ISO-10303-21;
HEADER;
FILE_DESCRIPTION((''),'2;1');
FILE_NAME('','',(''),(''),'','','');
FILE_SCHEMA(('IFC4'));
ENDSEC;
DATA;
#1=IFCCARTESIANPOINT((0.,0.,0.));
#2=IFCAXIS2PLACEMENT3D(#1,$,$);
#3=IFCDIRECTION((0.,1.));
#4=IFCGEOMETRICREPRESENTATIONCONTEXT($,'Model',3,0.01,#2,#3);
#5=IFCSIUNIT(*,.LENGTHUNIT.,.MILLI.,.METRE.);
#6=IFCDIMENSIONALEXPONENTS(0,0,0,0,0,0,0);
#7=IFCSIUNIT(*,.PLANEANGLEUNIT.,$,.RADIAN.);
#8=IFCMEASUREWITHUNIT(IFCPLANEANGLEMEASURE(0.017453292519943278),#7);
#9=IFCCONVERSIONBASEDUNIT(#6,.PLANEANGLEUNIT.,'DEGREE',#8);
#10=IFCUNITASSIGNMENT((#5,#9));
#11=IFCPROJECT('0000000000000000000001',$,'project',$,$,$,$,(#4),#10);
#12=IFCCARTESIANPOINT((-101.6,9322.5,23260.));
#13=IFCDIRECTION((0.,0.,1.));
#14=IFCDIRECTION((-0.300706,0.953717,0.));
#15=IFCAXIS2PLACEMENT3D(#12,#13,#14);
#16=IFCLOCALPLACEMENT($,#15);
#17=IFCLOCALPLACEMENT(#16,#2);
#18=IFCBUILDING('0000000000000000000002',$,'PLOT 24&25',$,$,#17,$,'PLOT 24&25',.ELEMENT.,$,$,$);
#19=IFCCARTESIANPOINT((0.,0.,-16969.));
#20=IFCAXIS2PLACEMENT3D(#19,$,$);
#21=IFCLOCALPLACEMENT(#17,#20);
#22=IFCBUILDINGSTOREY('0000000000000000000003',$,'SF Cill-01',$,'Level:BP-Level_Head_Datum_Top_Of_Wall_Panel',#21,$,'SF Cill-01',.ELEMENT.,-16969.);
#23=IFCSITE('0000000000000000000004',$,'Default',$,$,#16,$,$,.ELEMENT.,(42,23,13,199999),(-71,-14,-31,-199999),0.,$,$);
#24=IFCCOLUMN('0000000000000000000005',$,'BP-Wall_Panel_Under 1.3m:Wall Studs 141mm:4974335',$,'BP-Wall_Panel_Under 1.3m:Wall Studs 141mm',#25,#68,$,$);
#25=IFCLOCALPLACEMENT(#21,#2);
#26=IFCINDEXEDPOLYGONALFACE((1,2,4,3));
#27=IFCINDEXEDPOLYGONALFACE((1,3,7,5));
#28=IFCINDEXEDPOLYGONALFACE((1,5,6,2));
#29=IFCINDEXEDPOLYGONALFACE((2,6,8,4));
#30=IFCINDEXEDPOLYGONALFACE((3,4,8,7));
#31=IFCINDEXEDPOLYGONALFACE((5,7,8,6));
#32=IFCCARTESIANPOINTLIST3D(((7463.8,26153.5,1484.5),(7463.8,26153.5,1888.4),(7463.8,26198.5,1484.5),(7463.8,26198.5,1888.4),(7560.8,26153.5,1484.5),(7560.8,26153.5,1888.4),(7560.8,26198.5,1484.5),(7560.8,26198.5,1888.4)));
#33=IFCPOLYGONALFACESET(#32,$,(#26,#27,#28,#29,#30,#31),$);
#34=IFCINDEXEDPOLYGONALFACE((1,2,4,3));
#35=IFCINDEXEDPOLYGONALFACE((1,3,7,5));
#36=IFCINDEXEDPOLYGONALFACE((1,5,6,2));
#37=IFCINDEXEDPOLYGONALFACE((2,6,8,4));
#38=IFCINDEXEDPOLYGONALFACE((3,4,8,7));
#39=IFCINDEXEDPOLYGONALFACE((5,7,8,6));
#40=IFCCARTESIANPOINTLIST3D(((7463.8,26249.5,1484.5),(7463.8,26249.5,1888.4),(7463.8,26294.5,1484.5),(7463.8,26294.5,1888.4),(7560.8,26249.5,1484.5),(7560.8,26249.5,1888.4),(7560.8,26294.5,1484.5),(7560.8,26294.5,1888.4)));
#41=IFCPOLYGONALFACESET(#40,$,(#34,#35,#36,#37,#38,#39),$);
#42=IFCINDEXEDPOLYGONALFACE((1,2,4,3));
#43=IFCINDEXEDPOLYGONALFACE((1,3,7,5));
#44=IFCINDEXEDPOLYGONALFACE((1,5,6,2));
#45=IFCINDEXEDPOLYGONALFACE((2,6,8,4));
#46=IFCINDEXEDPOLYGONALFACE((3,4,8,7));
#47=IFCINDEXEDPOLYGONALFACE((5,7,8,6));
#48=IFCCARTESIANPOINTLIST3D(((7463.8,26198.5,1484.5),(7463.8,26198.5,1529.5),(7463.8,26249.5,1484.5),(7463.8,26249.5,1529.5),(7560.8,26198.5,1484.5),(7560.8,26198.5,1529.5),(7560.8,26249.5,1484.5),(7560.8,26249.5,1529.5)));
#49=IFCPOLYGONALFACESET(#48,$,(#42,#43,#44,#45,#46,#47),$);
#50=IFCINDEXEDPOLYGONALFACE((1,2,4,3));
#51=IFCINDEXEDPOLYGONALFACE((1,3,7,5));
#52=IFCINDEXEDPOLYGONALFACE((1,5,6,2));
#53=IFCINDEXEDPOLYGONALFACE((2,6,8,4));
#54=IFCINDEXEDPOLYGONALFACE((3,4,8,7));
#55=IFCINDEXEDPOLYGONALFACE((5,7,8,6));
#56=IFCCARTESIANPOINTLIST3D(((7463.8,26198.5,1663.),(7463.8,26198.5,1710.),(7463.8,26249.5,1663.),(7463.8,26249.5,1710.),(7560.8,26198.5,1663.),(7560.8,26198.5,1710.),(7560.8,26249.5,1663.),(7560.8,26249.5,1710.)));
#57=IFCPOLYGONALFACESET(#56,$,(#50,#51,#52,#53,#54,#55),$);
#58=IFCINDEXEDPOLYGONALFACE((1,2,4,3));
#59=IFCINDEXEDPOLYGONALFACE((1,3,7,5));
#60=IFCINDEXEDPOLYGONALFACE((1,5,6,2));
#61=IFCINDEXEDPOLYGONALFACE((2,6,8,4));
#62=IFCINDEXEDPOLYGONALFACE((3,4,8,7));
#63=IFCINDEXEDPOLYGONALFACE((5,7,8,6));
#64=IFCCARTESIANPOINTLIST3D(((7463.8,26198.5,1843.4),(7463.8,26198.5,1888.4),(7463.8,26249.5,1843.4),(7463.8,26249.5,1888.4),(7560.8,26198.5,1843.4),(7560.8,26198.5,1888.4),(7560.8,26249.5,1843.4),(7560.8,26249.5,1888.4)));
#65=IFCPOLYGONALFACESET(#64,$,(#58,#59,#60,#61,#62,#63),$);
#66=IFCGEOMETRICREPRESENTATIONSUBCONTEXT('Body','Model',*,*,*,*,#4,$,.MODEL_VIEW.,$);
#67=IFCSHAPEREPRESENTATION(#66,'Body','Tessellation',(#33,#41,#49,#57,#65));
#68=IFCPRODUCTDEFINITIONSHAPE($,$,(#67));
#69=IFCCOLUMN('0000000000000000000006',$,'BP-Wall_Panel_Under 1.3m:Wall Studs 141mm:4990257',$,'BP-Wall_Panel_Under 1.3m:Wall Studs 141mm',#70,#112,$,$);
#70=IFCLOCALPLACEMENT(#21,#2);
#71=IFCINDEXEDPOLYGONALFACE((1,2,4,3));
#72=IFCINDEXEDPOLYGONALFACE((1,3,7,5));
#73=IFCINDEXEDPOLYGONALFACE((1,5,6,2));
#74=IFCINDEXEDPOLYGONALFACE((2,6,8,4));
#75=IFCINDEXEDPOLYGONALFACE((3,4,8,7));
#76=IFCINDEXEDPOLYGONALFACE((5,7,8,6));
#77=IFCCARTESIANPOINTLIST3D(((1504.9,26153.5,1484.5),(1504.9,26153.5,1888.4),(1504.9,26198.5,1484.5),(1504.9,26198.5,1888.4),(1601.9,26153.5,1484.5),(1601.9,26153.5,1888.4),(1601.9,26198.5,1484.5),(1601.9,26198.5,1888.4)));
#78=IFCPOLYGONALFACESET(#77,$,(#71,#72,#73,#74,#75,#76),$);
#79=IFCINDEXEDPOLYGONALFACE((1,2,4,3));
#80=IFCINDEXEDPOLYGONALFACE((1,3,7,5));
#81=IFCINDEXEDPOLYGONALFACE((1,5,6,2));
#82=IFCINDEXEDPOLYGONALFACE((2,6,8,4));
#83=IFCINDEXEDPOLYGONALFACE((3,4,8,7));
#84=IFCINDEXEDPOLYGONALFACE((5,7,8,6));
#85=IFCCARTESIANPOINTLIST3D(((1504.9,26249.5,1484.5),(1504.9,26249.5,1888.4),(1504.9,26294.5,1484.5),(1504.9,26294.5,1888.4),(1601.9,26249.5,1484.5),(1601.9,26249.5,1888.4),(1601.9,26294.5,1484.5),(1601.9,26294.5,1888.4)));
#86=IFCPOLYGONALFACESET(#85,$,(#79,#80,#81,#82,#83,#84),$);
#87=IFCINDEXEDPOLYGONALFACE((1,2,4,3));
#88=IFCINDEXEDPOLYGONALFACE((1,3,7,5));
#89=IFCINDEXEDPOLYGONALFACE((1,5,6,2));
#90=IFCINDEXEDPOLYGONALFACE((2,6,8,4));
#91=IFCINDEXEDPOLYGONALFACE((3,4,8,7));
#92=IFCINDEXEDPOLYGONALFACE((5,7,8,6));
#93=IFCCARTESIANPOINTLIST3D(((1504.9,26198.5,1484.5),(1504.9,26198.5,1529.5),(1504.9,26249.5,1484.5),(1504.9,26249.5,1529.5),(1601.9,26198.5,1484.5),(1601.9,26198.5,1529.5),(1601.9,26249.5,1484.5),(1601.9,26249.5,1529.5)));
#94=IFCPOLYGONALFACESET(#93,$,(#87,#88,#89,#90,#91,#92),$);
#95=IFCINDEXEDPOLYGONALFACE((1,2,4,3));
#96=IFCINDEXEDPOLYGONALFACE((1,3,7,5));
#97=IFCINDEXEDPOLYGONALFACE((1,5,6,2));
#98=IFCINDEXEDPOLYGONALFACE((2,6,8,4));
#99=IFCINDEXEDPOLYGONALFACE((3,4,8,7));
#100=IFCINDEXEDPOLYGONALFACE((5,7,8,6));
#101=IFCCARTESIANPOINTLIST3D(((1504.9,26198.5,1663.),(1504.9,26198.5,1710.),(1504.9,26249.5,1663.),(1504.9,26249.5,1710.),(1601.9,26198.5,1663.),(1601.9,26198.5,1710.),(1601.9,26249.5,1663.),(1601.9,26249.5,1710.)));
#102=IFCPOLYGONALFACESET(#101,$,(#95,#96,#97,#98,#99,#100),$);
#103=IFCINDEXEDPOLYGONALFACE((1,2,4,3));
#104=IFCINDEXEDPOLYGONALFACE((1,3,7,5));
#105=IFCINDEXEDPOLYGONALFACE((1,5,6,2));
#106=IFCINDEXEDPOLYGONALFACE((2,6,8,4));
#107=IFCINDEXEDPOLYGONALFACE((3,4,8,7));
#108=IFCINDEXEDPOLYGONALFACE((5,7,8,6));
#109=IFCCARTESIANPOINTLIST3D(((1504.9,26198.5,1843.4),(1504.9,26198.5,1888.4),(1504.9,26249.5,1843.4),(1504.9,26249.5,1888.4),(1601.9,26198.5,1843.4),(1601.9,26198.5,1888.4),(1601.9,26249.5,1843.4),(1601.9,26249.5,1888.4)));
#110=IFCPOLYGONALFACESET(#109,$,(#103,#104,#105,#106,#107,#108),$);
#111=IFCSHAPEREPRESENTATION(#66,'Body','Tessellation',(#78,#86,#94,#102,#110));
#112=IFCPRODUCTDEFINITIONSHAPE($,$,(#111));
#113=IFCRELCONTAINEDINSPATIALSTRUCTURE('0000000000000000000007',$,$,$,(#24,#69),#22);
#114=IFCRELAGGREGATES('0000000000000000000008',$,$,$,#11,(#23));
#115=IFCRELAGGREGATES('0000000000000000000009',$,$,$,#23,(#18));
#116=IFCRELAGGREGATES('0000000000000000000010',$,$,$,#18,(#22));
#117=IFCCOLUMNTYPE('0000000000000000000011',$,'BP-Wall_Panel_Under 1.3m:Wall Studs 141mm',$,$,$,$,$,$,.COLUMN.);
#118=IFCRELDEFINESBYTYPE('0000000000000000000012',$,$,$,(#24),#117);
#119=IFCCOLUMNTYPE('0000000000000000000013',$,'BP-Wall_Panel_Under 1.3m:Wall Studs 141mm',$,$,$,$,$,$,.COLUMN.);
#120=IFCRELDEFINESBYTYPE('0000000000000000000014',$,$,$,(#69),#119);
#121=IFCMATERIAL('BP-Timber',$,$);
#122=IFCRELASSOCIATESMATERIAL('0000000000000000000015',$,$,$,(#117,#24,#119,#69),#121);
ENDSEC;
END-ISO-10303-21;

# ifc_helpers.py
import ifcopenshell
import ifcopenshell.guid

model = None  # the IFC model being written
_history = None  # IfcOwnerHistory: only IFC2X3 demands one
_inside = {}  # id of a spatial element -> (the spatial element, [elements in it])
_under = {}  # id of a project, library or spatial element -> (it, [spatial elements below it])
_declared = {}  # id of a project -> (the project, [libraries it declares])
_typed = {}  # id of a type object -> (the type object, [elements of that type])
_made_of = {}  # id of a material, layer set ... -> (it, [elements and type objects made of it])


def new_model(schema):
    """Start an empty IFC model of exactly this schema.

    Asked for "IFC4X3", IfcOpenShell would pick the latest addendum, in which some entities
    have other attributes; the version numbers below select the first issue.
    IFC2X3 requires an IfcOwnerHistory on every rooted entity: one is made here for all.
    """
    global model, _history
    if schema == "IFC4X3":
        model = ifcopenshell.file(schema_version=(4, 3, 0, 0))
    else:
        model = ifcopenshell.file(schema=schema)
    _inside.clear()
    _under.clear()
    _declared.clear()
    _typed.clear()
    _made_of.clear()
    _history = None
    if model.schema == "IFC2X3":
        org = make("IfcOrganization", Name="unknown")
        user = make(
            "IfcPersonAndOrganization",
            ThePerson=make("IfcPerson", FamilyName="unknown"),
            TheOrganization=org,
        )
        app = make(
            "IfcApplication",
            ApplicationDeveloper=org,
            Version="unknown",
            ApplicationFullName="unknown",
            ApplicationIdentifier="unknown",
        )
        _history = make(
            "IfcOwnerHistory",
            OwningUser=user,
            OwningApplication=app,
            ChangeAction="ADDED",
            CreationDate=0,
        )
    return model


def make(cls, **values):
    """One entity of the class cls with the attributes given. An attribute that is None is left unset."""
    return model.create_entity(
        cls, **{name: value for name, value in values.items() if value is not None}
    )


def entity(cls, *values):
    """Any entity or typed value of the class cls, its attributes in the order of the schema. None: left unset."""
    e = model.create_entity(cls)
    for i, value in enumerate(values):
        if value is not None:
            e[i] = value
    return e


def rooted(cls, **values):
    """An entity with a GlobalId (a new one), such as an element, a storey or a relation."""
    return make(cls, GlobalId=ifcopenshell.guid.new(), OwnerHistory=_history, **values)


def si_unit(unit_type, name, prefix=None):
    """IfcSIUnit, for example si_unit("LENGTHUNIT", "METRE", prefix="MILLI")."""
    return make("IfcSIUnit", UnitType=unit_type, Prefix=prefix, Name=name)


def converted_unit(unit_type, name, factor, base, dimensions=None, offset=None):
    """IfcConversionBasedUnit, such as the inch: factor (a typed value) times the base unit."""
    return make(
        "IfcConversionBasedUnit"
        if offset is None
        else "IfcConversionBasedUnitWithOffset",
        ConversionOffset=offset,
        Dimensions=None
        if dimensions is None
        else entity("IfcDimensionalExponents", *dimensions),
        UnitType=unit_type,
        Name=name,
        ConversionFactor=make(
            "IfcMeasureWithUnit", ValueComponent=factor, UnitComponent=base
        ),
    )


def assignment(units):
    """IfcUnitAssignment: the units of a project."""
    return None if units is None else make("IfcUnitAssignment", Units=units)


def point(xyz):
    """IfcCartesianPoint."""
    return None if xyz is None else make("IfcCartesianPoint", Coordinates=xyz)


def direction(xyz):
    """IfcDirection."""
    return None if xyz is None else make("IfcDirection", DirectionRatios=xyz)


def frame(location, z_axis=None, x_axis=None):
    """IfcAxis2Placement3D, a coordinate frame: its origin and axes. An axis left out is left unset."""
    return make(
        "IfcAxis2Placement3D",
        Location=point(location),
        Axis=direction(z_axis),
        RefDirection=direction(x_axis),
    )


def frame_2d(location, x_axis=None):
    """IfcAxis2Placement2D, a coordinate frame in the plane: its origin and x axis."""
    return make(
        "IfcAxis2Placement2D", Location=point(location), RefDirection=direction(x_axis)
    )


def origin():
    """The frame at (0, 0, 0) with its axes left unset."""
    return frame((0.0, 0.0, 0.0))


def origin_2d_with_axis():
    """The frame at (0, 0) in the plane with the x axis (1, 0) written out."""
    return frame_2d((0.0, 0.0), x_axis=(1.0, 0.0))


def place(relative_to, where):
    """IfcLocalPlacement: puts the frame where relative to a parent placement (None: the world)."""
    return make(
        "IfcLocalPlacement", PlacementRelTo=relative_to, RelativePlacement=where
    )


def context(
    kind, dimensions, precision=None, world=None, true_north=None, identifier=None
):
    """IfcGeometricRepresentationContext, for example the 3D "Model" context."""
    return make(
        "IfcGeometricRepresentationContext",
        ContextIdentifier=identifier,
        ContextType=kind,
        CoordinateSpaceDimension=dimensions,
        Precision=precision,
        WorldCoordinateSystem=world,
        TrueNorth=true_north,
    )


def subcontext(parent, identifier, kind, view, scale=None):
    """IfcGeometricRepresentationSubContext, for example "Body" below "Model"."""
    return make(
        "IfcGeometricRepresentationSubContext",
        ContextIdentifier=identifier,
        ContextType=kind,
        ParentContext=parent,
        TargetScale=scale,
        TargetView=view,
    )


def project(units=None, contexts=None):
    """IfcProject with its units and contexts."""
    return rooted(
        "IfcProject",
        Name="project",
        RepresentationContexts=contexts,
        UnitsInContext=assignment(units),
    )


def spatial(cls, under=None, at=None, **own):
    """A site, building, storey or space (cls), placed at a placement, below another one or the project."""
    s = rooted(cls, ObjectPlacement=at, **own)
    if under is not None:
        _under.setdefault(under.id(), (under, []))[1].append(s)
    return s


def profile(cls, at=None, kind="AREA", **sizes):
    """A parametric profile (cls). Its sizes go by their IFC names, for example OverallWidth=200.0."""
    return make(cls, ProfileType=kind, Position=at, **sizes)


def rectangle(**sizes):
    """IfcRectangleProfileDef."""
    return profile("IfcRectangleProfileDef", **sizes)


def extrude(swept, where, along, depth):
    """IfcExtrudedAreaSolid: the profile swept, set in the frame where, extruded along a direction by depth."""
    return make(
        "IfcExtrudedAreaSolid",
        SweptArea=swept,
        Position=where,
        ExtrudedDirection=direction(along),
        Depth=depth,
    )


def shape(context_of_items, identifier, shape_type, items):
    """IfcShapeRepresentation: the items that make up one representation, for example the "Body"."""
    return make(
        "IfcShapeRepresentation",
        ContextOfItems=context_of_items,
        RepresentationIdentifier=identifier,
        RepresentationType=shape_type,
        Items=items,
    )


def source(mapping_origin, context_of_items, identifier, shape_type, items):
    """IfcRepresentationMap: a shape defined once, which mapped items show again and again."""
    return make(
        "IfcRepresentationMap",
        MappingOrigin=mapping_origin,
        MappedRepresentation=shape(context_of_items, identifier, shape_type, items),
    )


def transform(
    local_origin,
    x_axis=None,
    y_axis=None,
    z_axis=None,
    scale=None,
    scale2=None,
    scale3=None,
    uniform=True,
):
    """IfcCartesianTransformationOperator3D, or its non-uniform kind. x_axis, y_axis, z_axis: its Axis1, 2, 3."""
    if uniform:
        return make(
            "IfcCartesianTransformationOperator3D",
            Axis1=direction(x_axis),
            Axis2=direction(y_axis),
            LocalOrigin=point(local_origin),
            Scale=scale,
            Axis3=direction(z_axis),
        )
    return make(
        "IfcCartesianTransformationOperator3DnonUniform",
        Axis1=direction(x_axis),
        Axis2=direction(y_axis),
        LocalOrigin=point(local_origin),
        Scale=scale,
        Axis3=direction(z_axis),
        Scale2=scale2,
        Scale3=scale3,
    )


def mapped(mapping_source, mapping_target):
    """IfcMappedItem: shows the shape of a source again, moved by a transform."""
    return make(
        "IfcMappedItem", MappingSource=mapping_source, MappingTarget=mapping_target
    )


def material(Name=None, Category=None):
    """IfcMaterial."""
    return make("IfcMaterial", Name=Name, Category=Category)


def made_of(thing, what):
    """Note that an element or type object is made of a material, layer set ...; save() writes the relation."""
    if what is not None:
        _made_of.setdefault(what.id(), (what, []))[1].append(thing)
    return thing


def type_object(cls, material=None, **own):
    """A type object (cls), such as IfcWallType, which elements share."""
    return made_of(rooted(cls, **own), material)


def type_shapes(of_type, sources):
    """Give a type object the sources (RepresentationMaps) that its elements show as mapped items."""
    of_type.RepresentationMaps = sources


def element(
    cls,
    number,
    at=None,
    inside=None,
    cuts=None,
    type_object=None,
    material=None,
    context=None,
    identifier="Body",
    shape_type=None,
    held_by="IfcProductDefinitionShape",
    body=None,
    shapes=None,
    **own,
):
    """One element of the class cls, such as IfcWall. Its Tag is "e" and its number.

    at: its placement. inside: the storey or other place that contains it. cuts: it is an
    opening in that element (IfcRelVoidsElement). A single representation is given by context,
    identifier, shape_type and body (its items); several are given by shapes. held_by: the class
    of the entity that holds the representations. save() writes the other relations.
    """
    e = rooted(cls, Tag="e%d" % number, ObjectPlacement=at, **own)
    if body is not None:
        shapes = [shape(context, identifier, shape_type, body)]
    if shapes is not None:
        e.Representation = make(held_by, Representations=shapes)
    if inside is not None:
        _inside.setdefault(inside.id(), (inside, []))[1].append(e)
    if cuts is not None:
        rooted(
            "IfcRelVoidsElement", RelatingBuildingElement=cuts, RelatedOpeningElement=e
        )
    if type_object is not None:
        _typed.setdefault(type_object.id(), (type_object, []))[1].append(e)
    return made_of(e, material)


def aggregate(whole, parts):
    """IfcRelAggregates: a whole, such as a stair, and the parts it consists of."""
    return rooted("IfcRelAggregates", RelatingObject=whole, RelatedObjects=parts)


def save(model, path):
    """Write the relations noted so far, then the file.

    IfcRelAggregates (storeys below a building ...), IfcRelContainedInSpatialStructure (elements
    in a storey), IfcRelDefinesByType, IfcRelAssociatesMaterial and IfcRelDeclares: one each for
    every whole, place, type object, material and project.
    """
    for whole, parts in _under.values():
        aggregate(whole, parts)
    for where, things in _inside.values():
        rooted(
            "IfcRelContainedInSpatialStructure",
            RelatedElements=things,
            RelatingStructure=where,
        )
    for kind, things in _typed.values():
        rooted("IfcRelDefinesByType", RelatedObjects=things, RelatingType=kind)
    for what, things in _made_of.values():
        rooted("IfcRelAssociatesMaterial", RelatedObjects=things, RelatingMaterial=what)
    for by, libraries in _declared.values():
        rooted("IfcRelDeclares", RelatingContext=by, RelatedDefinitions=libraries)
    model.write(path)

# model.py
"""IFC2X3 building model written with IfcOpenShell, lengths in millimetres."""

from ifc_helpers import new_model, entity, si_unit, converted_unit, direction, frame, frame_2d, origin, origin_2d_with_axis, place, context, subcontext, project, spatial, rectangle, extrude, source, transform, mapped, material, type_object, type_shapes, element, save


model = new_model("IFC2X3")

# Units and contexts
model_context = context("Model", 3, precision=0.01, world=origin(), true_north=direction((0.0, 1.0)))
body_context = subcontext(model_context, "Body", "Model", "MODEL_VIEW")
ifc_project = project(units=[si_unit("LENGTHUNIT", "METRE", prefix="MILLI"), converted_unit("PLANEANGLEUNIT", "DEGREE", entity("IfcPlaneAngleMeasure", 0.017453292519943278), si_unit("PLANEANGLEUNIT", "RADIAN"), dimensions=[0, 0, 0, 0, 0, 0, 0])], contexts=[model_context])

# Site, building, storey
site_placement = place(None, frame((-101.6, 9322.5, 23260.0), z_axis=(0.0, 0.0, 1.0), x_axis=(-0.300706, 0.953717, 0.0)))
site = spatial("IfcSite", under=ifc_project, at=site_placement, Name="Default", CompositionType="ELEMENT", RefLatitude=(42, 23, 13, 199999), RefLongitude=(-71, -14, -31, -199999), RefElevation=0.0)
building_placement = place(site_placement, origin())
building = spatial("IfcBuilding", under=site, at=building_placement, Name="PLOT 24&25", LongName="PLOT 24&25", CompositionType="ELEMENT")
storey_placement = place(building_placement, frame((0.0, 0.0, -16969.0)))
storey = spatial("IfcBuildingStorey", under=building, at=storey_placement, Name="SF Cill-01", ObjectType="Level:BP-Level_Head_Datum_Top_Of_Wall_Panel", LongName="SF Cill-01", CompositionType="ELEMENT", Elevation=-16969.0)

# Columns
ifc_material_1 = material(Name="BP-Timber")
column_type_1 = type_object("IfcColumnType", Name="BP-Wall_Panel_Under 1.3m:Wall Studs 141mm", PredefinedType="COLUMN", material=ifc_material_1)
shared_shape_1 = source(origin(), body_context, "Body", "SweptSolid", [
    extrude(rectangle(XDim=97.0, YDim=45.0, at=frame_2d((0.0, 0.0), x_axis=(1.0, 0.0))), frame((7512.3, 26176.0, -15484.5), z_axis=(0.0, 0.0, 1.0), x_axis=(-1.0, 0.0, 0.0)), (0.0, 0.0, 1.0), 403.8),
    extrude(rectangle(XDim=97.0, YDim=45.0, at=frame_2d((0.0, 0.0), x_axis=(1.0, 0.0))), frame((7512.3, 26272.0, -15484.5), z_axis=(0.0, 0.0, 1.0), x_axis=(-1.0, 0.0, 0.0)), (0.0, 0.0, 1.0), 403.8),
    extrude(rectangle(XDim=51.0, YDim=97.0, at=origin_2d_with_axis()), frame((7512.3, 26224.0, -15484.5), z_axis=(0.0, 0.0, 1.0), x_axis=(0.0, -1.0, 0.0)), (0.0, 0.0, 1.0), 45.0),
    extrude(rectangle(XDim=51.0, YDim=97.0, at=frame_2d((0.0, 0.0), x_axis=(1.0, 0.0))), frame((7512.3, 26224.0, -15306.0), z_axis=(0.0, 0.0, 1.0), x_axis=(0.0, -1.0, 0.0)), (0.0, 0.0, 1.0), 47.0),
    extrude(rectangle(XDim=51.0, YDim=97.0, at=frame_2d((0.0, 0.0), x_axis=(1.0, 0.0))), frame((7512.3, 26224.0, -15125.6), z_axis=(0.0, 0.0, 1.0), x_axis=(0.0, -1.0, 0.0)), (0.0, 0.0, 1.0), 45.0),
])
type_shapes(column_type_1, [shared_shape_1])
column_1_placement = place(storey_placement, frame((0.0, 0.0, 16969.0)))
element("IfcColumn", 1, at=column_1_placement, inside=storey, type_object=column_type_1, material=ifc_material_1, Name="BP-Wall_Panel_Under 1.3m:Wall Studs 141mm:4974335", ObjectType="BP-Wall_Panel_Under 1.3m:Wall Studs 141mm", context=body_context, shape_type="MappedRepresentation", body=[
    mapped(shared_shape_1, transform((0.0, 0.0, 0.0), scale=1.0)),
])
column_type_2 = type_object("IfcColumnType", Name="BP-Wall_Panel_Under 1.3m:Wall Studs 141mm", PredefinedType="COLUMN", material=ifc_material_1)
shared_shape_2 = source(origin(), body_context, "Body", "SweptSolid", [
    extrude(rectangle(XDim=97.0, YDim=45.0, at=origin_2d_with_axis()), frame((1553.4, 26176.0, -15484.5), z_axis=(0.0, 0.0, 1.0), x_axis=(-1.0, 0.0, 0.0)), (0.0, 0.0, 1.0), 403.8),
    extrude(rectangle(XDim=97.0, YDim=45.0, at=origin_2d_with_axis()), frame((1553.4, 26272.0, -15484.5), z_axis=(0.0, 0.0, 1.0), x_axis=(-1.0, 0.0, 0.0)), (0.0, 0.0, 1.0), 403.8),
    extrude(rectangle(XDim=51.0, YDim=97.0, at=frame_2d((0.0, 0.0), x_axis=(1.0, 0.0))), frame((1553.4, 26224.0, -15484.5), z_axis=(0.0, 0.0, 1.0), x_axis=(0.0, -1.0, 0.0)), (0.0, 0.0, 1.0), 45.0),
    extrude(rectangle(XDim=51.0, YDim=97.0, at=frame_2d((0.0, 0.0), x_axis=(1.0, 0.0))), frame((1553.4, 26224.0, -15306.0), z_axis=(0.0, 0.0, 1.0), x_axis=(0.0, -1.0, 0.0)), (0.0, 0.0, 1.0), 47.0),
    extrude(rectangle(XDim=51.0, YDim=97.0, at=frame_2d((0.0, 0.0), x_axis=(1.0, 0.0))), frame((1553.4, 26224.0, -15125.6), z_axis=(0.0, 0.0, 1.0), x_axis=(0.0, -1.0, 0.0)), (0.0, 0.0, 1.0), 45.0),
])
type_shapes(column_type_2, [shared_shape_2])
column_2_placement = place(storey_placement, frame((0.0, 0.0, 16969.0)))
element("IfcColumn", 2, at=column_2_placement, inside=storey, type_object=column_type_2, material=ifc_material_1, Name="BP-Wall_Panel_Under 1.3m:Wall Studs 141mm:4990257", ObjectType="BP-Wall_Panel_Under 1.3m:Wall Studs 141mm", context=body_context, shape_type="MappedRepresentation", body=[
    mapped(shared_shape_2, transform((0.0, 0.0, 0.0), scale=1.0)),
])

save(model, "model.ifc")
